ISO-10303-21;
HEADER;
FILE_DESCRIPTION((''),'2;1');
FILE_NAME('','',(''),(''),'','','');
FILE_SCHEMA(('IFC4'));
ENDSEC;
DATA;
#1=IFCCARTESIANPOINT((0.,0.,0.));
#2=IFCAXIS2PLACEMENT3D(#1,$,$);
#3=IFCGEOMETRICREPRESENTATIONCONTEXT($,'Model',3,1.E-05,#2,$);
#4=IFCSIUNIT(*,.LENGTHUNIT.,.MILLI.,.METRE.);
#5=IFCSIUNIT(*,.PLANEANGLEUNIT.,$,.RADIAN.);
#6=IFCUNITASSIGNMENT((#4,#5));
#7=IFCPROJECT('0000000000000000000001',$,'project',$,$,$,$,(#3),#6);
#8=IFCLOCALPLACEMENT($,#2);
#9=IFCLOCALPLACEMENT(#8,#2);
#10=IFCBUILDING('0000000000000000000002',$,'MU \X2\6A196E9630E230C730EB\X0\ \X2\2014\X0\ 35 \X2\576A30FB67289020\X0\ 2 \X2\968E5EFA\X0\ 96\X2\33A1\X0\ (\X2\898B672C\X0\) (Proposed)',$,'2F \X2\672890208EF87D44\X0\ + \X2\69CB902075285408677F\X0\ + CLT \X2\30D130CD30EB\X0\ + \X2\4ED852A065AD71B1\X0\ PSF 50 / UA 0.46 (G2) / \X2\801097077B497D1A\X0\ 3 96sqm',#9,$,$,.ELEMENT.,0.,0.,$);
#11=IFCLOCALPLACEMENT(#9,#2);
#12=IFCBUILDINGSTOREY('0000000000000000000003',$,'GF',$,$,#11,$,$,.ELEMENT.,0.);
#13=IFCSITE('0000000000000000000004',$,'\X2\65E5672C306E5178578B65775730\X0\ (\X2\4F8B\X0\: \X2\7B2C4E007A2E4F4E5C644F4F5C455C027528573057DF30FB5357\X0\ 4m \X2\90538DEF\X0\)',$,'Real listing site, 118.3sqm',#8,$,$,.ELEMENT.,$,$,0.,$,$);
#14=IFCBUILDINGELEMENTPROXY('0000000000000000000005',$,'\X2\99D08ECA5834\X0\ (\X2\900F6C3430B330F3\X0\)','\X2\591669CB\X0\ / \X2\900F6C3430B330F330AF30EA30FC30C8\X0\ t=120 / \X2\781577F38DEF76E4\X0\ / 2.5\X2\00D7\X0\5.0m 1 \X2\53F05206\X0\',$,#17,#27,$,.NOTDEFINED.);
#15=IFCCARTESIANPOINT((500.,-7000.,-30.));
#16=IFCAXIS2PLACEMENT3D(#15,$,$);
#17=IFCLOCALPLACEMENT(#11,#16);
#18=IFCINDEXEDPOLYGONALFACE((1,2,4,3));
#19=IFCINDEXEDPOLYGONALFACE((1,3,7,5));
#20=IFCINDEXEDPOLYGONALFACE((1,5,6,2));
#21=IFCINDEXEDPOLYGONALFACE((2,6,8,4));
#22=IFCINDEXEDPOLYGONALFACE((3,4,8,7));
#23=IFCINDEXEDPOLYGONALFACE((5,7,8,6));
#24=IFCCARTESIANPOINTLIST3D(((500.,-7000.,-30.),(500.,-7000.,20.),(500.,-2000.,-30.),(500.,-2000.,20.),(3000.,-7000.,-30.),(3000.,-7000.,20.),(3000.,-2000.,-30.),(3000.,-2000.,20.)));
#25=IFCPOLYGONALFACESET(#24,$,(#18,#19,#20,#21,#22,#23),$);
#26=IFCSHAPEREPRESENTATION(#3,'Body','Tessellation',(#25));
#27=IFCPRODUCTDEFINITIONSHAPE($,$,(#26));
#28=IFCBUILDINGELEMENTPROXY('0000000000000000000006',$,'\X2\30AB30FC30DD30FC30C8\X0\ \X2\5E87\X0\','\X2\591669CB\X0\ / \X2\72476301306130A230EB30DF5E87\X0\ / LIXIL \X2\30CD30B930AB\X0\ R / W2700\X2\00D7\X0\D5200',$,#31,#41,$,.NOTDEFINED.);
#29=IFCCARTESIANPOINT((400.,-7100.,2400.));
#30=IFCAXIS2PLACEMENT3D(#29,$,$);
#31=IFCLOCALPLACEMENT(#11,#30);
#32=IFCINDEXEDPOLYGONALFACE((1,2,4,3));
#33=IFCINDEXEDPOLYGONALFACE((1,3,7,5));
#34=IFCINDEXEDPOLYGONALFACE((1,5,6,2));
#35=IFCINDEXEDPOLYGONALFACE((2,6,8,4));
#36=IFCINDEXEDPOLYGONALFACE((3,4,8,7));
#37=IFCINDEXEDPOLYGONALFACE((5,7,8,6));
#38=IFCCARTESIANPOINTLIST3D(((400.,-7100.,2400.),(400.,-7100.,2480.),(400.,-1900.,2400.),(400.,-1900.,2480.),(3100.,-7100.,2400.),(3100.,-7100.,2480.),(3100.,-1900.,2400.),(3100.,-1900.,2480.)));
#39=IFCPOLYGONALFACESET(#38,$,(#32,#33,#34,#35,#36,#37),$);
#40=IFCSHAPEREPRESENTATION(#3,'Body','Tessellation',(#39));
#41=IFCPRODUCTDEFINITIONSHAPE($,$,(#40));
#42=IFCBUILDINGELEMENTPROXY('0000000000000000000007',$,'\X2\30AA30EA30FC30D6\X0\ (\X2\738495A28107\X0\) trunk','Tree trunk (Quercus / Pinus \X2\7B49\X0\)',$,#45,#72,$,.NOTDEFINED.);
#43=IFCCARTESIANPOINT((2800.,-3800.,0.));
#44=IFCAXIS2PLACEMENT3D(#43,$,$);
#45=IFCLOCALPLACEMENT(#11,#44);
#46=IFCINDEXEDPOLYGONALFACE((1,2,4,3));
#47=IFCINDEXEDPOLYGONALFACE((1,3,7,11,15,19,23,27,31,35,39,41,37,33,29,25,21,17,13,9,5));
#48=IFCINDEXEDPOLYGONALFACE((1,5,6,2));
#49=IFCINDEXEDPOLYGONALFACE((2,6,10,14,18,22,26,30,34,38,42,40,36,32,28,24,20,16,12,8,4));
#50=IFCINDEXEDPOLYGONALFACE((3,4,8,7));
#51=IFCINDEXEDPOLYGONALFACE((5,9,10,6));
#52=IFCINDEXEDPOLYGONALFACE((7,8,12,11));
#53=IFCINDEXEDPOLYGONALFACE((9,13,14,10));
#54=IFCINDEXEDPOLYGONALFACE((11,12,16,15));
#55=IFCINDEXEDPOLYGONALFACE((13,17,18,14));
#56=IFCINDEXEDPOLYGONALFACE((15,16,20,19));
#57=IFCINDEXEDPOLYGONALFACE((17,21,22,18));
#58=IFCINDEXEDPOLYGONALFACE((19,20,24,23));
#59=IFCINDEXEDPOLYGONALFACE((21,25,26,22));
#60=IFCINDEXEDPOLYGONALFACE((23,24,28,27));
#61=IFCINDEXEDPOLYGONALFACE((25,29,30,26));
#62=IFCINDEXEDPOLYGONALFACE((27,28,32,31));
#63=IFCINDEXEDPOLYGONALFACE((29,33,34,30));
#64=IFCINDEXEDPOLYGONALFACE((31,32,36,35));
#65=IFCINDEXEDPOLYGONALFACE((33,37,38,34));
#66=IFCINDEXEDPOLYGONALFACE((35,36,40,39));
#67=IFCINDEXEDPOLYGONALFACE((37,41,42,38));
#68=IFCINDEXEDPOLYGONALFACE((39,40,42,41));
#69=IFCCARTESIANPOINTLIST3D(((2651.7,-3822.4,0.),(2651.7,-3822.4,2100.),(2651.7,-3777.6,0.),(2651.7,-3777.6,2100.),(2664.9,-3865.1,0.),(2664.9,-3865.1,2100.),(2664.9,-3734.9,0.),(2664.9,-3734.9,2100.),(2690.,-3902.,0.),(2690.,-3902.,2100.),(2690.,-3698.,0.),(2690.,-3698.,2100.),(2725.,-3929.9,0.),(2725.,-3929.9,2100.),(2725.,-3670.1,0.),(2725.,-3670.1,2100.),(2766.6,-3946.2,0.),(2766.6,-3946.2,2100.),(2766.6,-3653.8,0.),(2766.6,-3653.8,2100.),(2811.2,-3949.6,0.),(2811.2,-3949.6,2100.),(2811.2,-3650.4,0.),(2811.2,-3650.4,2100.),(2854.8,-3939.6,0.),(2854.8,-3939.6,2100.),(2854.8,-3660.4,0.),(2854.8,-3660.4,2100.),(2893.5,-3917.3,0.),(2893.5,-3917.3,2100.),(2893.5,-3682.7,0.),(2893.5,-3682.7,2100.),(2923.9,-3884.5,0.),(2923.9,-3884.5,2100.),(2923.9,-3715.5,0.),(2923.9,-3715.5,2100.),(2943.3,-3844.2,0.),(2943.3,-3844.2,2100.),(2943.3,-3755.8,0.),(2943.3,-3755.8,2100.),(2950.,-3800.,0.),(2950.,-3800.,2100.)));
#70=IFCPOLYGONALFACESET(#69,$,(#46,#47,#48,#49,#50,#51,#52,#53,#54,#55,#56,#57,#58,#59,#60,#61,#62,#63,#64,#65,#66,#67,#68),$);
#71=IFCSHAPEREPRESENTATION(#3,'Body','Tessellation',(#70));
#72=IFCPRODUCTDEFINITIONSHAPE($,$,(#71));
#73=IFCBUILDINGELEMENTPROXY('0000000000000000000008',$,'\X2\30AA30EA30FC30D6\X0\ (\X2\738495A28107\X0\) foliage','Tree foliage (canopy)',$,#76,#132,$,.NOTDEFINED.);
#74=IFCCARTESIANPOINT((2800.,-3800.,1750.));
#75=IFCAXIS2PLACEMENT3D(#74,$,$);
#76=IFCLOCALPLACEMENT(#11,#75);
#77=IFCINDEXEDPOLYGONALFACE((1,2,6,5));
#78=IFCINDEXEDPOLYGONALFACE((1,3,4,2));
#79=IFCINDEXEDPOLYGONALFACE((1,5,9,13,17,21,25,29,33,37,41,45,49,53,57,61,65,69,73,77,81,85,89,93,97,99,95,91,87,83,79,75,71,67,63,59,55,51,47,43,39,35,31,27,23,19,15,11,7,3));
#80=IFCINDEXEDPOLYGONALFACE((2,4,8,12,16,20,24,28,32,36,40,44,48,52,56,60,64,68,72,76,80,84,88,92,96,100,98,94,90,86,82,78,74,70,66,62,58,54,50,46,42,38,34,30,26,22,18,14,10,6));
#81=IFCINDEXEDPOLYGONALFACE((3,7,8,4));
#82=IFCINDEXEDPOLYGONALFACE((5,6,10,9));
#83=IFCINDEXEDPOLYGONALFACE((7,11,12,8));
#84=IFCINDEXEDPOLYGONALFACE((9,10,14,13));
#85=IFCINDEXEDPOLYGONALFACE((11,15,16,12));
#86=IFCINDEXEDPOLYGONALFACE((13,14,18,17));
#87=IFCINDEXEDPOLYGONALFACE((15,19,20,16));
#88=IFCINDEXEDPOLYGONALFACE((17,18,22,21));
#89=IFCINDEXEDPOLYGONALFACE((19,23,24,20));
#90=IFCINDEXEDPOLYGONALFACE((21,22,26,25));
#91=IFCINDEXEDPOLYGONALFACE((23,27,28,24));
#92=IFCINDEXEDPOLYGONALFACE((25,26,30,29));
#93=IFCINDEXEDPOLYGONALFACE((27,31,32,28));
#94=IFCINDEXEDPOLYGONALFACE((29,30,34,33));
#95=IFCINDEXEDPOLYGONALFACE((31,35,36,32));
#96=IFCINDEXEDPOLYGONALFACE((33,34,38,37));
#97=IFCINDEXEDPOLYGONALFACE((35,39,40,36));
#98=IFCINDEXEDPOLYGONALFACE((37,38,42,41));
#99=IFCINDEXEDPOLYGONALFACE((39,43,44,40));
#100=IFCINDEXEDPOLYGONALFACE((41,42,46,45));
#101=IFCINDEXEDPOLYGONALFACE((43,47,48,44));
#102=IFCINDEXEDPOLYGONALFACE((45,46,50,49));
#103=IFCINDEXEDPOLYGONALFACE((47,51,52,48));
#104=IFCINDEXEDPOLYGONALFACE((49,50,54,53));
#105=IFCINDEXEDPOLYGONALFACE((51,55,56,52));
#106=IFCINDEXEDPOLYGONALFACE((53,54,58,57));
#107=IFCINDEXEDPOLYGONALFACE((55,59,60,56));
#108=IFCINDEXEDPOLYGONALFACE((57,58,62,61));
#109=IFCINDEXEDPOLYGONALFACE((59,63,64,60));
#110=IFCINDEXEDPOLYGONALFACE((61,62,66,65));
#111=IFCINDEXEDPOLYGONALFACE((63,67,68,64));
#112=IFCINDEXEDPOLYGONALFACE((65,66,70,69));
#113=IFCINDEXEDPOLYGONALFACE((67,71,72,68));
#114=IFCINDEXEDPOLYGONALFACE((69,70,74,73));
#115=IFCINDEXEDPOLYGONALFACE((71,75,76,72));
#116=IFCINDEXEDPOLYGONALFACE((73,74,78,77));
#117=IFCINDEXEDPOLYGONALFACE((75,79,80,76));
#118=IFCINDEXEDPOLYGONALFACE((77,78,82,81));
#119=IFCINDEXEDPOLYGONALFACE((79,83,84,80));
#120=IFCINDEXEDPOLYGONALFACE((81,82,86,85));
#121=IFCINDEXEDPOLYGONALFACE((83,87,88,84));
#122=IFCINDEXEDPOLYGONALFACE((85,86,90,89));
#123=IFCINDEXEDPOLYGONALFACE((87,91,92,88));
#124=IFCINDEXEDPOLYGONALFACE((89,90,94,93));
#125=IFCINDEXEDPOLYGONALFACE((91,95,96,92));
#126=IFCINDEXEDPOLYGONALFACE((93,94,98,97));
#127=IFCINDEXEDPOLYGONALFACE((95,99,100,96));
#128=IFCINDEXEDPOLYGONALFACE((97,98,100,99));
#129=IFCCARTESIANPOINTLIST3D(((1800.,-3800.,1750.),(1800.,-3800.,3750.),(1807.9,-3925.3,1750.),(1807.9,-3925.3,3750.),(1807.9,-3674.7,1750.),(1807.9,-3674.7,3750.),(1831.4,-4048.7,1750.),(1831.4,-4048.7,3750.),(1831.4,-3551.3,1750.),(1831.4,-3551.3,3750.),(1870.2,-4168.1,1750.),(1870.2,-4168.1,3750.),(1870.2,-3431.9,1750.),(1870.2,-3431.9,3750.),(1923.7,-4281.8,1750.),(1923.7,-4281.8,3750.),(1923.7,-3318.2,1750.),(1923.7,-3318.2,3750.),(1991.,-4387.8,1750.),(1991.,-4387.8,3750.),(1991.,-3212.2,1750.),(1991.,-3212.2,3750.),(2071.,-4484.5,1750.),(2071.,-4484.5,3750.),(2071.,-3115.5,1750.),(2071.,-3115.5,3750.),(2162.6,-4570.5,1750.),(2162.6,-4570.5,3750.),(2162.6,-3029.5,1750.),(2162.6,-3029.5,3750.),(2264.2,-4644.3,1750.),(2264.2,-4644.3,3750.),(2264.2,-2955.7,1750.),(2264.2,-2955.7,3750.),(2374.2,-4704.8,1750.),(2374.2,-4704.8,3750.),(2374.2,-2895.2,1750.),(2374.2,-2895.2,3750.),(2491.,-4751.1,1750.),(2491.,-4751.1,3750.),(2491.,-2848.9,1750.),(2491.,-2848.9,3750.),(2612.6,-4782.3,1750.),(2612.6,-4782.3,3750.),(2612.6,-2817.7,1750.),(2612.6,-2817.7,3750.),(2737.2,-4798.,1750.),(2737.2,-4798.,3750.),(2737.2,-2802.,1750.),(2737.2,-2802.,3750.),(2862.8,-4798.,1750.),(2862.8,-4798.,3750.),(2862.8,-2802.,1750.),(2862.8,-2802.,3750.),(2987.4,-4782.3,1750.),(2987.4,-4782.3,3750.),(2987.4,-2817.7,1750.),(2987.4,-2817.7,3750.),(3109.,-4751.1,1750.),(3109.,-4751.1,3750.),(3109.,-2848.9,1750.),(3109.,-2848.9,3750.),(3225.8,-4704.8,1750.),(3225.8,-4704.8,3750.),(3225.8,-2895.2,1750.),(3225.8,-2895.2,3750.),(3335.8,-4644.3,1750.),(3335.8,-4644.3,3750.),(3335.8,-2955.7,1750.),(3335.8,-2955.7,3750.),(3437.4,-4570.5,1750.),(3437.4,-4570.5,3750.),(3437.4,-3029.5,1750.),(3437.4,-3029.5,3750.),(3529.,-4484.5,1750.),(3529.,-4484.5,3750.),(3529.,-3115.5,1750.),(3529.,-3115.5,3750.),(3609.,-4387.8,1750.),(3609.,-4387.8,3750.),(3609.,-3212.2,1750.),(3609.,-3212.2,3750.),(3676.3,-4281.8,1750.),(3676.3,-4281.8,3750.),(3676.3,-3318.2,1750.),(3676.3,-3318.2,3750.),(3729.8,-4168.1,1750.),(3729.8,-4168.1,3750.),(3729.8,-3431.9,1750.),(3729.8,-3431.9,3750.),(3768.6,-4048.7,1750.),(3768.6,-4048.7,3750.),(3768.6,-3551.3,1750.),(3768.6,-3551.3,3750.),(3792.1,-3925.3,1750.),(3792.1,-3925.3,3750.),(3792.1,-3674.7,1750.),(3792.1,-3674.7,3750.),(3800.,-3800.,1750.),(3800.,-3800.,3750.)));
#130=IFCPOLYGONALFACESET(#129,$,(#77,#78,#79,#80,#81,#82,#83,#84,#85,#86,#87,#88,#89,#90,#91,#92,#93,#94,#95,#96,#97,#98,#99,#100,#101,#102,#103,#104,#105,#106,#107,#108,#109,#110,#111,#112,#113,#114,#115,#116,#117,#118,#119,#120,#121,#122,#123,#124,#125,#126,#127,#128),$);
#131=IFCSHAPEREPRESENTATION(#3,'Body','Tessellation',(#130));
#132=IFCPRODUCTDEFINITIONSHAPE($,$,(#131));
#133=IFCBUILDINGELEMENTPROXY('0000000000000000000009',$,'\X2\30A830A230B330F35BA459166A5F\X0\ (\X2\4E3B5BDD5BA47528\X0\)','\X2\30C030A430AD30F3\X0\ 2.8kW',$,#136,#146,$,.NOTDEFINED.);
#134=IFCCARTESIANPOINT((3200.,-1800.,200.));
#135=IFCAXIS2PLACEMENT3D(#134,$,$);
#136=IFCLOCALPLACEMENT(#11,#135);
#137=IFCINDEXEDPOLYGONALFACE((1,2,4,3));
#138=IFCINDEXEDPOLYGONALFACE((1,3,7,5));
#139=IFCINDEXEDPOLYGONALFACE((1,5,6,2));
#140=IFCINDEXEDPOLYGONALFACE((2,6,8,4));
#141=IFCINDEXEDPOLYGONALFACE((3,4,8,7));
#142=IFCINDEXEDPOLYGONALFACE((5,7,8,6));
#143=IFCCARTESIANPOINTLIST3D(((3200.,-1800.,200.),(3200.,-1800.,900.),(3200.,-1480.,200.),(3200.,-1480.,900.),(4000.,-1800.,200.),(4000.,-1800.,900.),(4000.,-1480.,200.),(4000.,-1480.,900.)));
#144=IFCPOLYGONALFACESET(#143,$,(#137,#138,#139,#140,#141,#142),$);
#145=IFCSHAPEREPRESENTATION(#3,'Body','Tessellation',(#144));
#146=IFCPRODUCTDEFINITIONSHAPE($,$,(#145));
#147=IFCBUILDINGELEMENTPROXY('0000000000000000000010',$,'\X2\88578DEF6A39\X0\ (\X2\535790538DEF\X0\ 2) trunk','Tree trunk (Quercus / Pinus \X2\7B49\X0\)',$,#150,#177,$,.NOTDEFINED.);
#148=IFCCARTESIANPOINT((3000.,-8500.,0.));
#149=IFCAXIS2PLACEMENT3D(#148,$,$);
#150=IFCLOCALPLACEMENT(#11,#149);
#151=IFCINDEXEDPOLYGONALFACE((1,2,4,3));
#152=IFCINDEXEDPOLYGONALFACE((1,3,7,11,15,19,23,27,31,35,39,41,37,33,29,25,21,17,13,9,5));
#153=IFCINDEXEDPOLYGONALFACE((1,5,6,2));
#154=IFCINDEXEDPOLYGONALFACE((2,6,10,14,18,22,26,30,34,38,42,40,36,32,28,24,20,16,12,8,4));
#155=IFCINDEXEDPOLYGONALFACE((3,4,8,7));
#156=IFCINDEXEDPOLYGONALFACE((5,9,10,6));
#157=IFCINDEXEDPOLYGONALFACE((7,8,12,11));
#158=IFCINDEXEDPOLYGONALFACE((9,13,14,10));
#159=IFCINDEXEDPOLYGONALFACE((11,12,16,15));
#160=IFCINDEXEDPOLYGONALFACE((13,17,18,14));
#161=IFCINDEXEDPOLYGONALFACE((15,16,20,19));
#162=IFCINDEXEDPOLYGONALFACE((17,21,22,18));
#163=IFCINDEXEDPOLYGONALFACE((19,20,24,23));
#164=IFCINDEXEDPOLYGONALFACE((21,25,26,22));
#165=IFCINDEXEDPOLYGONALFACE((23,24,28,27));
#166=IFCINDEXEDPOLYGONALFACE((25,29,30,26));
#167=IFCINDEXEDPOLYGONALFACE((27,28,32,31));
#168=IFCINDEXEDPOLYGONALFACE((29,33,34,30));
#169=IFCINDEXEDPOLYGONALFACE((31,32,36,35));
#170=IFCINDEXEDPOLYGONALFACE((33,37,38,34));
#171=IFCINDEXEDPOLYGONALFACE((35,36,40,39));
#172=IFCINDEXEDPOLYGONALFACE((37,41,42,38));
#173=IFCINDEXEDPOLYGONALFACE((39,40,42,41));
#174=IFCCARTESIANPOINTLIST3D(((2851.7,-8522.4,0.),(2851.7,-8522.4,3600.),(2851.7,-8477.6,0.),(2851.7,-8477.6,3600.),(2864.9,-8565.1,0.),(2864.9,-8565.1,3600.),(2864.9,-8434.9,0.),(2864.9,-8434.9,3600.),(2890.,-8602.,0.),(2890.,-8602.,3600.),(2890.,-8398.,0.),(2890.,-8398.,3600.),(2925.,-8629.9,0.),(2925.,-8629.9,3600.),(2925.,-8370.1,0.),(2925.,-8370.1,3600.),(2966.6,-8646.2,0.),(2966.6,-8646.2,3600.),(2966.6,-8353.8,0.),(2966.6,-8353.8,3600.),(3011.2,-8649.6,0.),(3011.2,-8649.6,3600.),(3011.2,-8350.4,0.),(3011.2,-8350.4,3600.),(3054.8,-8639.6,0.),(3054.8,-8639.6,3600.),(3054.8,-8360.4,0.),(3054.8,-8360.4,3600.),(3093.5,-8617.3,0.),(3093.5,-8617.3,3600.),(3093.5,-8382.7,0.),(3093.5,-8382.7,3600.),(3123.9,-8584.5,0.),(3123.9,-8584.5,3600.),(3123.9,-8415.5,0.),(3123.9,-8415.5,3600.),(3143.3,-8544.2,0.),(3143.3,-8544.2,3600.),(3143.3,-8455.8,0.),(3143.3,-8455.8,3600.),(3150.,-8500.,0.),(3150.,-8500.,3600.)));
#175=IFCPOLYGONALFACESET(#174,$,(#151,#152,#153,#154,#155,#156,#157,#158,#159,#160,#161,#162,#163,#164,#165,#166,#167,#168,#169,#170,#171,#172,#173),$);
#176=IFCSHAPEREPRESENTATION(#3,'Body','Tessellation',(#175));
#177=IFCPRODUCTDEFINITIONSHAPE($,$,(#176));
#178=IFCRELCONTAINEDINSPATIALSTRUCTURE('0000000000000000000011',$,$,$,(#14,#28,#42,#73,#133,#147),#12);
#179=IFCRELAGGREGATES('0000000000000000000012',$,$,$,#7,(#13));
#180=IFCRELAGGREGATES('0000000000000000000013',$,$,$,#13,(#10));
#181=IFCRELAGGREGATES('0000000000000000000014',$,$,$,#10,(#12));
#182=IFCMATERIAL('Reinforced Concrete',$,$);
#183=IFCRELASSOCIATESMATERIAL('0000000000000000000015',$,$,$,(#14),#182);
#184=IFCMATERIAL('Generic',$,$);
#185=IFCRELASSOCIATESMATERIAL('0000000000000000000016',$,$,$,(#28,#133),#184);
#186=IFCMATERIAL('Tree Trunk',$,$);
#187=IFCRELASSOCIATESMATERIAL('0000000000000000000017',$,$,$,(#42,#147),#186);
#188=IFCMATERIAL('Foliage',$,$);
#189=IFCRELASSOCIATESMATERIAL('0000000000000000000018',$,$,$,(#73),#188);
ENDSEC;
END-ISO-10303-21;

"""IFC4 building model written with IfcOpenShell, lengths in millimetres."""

from ifc_helpers import new_model, si_unit, frame, frame_2d, origin, origin_2d, place, context, project, spatial, rectangle, circle, extrude, material, element, save


model = new_model("IFC4")

# Units and contexts
model_context = context("Model", 3, precision=1e-05, world=origin())
ifc_project = project(units=[si_unit("LENGTHUNIT", "METRE", prefix="MILLI"), si_unit("PLANEANGLEUNIT", "RADIAN")], contexts=[model_context])

# Site, building, storey
site_placement = place(None, origin())
site = spatial("IfcSite", under=ifc_project, at=site_placement, Name="日本の典型敷地 (例: 第一種低層住居専用地域・南 4m 道路)", ObjectType="Real listing site, 118.3sqm", CompositionType="ELEMENT", RefElevation=0.0)
building_placement = place(site_placement, origin())
building = spatial("IfcBuilding", under=site, at=building_placement, Name="MU 標準モデル — 35 坪・木造 2 階建 96㎡ (見本) (Proposed)", ObjectType="2F 木造軸組 + 構造用合板 + CLT パネル + 付加断熱 PSF 50 / UA 0.46 (G2) / 耐震等級 3 96sqm", CompositionType="ELEMENT", ElevationOfRefHeight=0.0, ElevationOfTerrain=0.0)
storey_placement = place(building_placement, origin())
storey = spatial("IfcBuildingStorey", under=building, at=storey_placement, Name="GF", CompositionType="ELEMENT", Elevation=0.0)

# Shared definitions
ifc_material_1 = material(Name="Reinforced Concrete")

# Shared definitions
ifc_material_2 = material(Name="Generic")

# Building element proxies
proxy_1_placement = place(storey_placement, frame((500.0, -7000.0, -30.0)))
element("IfcBuildingElementProxy", 1, at=proxy_1_placement, inside=storey, material=ifc_material_1, Name="駐車場 (透水コン)", Description="外構 / 透水コンクリート t=120 / 砕石路盤 / 2.5×5.0m 1 台分", PredefinedType="NOTDEFINED", context=model_context, shape_type="SweptSolid", body=[
    extrude(rectangle(XDim=2500.0, YDim=5000.0, at=frame_2d((1250.0, 2500.0))), frame((500.0, -7000.0, -30.0)), (0.0, 0.0, 1.0), 50.0),
])
proxy_2_placement = place(storey_placement, frame((400.0, -7100.0, 2400.0)))
element("IfcBuildingElementProxy", 2, at=proxy_2_placement, inside=storey, material=ifc_material_2, Name="カーポート 庇", Description="外構 / 片持ちアルミ庇 / LIXIL ネスカ R / W2700×D5200", PredefinedType="NOTDEFINED", context=model_context, shape_type="SweptSolid", body=[
    extrude(rectangle(XDim=2700.0, YDim=5200.0, at=frame_2d((1350.0, 2600.0))), frame((400.0, -7100.0, 2400.0)), (0.0, 0.0, 1.0), 80.0),
])
ifc_material_3 = material(Name="Tree Trunk")
proxy_3_placement = place(storey_placement, frame((2800.0, -3800.0, 0.0)))
element("IfcBuildingElementProxy", 3, at=proxy_3_placement, inside=storey, material=ifc_material_3, Name="オリーブ (玄関脇) trunk", Description="Tree trunk (Quercus / Pinus 等)", PredefinedType="NOTDEFINED", context=model_context, shape_type="SweptSolid", body=[
    extrude(circle(Radius=150.0, at=origin_2d()), frame((2800.0, -3800.0, 0.0)), (0.0, 0.0, 1.0), 2100.0),
])
ifc_material_4 = material(Name="Foliage")
proxy_4_placement = place(storey_placement, frame((2800.0, -3800.0, 1750.0)))
element("IfcBuildingElementProxy", 4, at=proxy_4_placement, inside=storey, material=ifc_material_4, Name="オリーブ (玄関脇) foliage", Description="Tree foliage (canopy)", PredefinedType="NOTDEFINED", context=model_context, shape_type="SweptSolid", body=[
    extrude(circle(Radius=1000.0, at=origin_2d()), frame((2800.0, -3800.0, 1750.0)), (0.0, 0.0, 1.0), 2000.0),
])
proxy_5_placement = place(storey_placement, frame((3200.0, -1800.0, 200.0)))
element("IfcBuildingElementProxy", 5, at=proxy_5_placement, inside=storey, material=ifc_material_2, Name="エアコン室外機 (主寝室用)", Description="ダイキン 2.8kW", PredefinedType="NOTDEFINED", context=model_context, shape_type="SweptSolid", body=[
    extrude(rectangle(XDim=800.0, YDim=320.0, at=frame_2d((400.0, 160.0))), frame((3200.0, -1800.0, 200.0)), (0.0, 0.0, 1.0), 700.0),
])
proxy_6_placement = place(storey_placement, frame((3000.0, -8500.0, 0.0)))
element("IfcBuildingElementProxy", 6, at=proxy_6_placement, inside=storey, material=ifc_material_3, Name="街路樹 (南道路 2) trunk", Description="Tree trunk (Quercus / Pinus 等)", PredefinedType="NOTDEFINED", context=model_context, shape_type="SweptSolid", body=[
    extrude(circle(Radius=150.0, at=origin_2d()), frame((3000.0, -8500.0, 0.0)), (0.0, 0.0, 1.0), 3600.0),
])

save(model, "model.ifc")
